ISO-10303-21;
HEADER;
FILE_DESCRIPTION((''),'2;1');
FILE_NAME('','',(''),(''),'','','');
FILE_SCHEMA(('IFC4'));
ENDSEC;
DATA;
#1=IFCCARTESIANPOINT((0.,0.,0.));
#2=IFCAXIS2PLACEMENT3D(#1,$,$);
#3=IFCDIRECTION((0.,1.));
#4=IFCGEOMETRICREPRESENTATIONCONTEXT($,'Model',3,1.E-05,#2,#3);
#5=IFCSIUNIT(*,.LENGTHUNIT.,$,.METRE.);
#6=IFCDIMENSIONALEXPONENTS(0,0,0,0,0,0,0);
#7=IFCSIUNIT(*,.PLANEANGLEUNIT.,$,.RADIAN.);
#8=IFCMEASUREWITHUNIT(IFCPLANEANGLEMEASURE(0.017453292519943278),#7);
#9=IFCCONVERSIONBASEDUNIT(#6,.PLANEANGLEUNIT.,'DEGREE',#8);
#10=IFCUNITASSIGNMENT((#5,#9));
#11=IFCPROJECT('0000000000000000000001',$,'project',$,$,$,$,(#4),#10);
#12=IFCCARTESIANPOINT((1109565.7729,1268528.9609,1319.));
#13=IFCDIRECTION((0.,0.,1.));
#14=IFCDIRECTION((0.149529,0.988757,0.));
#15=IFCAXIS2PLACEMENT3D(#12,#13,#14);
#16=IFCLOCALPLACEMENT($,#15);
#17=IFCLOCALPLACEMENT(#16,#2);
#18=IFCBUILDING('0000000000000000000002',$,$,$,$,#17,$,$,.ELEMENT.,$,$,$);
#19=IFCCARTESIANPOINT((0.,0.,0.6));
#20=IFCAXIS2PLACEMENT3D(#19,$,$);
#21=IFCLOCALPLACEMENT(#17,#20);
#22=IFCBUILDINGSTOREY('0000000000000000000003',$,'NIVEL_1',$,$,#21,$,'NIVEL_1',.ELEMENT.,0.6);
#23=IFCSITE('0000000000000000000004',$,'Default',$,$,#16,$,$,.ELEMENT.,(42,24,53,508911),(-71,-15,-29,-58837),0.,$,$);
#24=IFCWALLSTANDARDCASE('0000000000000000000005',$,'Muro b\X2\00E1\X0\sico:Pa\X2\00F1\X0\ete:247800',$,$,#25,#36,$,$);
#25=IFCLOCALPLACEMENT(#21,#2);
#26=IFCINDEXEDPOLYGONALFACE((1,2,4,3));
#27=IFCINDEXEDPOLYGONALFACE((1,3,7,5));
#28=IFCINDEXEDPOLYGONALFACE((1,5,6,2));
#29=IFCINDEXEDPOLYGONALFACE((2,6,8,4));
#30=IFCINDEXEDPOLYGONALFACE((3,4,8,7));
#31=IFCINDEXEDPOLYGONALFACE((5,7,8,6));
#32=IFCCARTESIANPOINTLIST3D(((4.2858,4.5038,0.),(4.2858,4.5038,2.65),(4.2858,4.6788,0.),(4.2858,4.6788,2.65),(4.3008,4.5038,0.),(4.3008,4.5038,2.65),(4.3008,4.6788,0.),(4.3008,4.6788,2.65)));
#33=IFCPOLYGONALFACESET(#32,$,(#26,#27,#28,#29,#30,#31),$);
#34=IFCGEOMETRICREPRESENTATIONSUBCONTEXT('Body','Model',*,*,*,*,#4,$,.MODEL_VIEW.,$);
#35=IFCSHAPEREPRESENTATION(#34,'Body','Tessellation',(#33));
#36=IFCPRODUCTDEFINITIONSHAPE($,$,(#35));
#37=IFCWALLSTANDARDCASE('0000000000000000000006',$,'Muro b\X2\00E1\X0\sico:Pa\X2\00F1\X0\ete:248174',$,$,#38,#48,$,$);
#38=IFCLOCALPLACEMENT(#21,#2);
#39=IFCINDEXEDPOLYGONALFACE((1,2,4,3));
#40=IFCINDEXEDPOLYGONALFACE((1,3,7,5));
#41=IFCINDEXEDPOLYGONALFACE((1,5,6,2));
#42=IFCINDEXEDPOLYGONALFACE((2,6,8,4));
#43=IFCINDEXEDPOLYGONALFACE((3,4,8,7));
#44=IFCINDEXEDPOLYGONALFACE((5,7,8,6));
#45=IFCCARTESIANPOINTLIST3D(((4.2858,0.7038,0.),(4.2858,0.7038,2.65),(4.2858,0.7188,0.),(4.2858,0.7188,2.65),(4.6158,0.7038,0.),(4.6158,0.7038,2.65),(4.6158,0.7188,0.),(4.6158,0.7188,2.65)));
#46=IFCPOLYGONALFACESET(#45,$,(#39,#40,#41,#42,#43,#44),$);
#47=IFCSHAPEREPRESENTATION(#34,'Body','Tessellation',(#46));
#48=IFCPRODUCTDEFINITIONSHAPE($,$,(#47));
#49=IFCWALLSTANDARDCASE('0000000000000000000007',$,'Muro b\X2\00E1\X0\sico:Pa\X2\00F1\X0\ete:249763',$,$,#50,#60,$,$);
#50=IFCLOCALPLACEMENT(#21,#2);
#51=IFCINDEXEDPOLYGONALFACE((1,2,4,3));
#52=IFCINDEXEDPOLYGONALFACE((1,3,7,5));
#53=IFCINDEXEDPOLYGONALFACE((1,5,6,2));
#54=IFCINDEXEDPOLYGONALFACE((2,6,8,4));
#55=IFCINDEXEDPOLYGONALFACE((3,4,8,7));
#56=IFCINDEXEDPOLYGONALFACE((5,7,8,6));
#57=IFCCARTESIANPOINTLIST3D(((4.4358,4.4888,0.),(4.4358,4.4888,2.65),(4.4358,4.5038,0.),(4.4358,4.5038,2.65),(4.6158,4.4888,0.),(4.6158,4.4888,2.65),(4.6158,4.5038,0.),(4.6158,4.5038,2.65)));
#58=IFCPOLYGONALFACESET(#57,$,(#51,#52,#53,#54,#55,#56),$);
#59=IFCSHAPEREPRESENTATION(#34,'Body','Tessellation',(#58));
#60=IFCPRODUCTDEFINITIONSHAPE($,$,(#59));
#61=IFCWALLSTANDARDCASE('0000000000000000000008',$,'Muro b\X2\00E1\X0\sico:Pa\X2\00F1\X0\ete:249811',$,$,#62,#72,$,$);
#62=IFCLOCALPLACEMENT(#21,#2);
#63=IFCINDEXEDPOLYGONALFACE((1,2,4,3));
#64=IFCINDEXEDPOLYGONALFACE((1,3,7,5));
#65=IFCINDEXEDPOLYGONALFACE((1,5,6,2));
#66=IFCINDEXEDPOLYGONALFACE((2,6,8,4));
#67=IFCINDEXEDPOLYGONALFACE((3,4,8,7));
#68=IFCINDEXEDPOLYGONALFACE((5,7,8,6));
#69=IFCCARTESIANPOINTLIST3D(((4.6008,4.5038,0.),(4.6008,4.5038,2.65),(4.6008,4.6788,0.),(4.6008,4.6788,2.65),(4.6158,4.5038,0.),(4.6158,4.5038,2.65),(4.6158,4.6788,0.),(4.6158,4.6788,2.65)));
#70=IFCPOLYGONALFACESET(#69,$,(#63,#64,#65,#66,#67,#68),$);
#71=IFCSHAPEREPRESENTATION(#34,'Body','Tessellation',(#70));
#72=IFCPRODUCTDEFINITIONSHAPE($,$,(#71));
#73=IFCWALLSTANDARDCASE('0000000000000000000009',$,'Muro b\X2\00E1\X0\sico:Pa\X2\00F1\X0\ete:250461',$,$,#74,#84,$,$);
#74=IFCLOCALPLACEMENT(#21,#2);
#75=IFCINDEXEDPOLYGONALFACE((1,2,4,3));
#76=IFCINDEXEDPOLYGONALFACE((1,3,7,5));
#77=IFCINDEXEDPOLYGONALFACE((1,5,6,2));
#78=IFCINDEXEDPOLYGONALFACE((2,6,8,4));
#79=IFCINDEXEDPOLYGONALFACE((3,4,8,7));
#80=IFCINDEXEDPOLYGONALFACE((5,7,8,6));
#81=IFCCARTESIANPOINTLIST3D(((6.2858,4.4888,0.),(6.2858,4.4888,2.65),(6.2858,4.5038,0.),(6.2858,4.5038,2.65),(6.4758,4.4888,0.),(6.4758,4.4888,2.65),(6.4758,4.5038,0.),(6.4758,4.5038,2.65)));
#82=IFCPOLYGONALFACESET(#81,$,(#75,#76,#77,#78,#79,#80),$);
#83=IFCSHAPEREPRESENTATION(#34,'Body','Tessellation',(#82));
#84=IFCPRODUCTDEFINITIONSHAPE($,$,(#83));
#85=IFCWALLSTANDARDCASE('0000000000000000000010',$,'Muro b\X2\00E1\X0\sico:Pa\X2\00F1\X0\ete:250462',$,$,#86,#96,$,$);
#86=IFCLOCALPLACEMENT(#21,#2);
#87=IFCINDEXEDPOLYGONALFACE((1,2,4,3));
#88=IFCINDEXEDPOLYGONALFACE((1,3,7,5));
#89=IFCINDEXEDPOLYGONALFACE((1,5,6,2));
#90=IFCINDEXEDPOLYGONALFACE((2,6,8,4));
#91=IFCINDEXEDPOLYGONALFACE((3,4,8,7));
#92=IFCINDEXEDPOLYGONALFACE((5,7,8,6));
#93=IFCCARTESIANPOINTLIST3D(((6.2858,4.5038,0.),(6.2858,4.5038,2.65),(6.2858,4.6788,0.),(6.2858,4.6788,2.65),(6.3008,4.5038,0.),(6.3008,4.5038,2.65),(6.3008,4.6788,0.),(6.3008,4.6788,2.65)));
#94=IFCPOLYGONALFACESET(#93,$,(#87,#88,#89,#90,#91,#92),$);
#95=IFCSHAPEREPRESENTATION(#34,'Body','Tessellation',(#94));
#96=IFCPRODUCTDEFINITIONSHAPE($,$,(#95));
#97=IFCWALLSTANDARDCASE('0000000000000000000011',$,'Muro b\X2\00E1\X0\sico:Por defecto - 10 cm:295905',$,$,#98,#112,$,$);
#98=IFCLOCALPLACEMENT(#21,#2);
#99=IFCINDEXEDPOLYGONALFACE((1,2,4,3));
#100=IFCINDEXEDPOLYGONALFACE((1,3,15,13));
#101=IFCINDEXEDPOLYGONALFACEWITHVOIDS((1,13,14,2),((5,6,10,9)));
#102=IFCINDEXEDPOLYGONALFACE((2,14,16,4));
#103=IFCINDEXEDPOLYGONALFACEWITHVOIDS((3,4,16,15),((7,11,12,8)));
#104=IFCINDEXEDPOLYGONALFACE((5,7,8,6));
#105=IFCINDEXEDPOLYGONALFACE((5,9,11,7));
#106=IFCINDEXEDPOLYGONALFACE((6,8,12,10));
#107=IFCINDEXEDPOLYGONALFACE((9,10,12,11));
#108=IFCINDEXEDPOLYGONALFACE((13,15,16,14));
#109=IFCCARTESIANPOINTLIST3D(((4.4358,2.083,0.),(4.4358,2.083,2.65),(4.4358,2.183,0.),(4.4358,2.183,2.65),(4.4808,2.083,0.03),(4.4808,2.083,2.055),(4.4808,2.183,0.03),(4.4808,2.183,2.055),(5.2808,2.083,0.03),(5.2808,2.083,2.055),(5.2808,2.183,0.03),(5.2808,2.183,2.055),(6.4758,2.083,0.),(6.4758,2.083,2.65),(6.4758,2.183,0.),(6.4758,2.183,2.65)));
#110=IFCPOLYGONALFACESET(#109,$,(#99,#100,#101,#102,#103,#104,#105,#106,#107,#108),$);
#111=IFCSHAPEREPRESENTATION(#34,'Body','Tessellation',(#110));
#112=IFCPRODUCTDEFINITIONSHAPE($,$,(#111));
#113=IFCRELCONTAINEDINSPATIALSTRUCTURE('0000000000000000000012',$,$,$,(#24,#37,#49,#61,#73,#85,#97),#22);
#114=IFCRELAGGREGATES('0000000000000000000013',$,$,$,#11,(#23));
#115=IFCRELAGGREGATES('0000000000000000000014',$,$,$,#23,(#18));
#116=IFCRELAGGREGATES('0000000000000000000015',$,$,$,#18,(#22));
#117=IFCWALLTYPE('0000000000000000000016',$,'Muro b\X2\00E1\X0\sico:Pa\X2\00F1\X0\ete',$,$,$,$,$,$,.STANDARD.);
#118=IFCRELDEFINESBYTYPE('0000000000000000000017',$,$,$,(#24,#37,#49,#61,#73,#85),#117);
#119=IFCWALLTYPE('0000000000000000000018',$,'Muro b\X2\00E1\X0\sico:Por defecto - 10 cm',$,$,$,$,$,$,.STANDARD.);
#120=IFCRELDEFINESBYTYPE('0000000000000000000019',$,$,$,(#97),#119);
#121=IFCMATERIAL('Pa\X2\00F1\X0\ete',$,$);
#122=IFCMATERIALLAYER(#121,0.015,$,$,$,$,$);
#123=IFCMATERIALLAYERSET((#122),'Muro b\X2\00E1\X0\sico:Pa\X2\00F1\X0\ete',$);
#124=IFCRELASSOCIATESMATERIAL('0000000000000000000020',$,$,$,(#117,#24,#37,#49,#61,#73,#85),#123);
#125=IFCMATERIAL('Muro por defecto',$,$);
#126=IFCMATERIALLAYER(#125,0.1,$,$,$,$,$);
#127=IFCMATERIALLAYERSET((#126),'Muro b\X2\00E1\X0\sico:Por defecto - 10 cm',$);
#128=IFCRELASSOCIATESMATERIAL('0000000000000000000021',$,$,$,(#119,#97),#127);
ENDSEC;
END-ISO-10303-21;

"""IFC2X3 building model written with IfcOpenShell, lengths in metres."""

from ifc_helpers import new_model, entity, si_unit, converted_unit, direction, frame, frame_2d, origin, place, context, subcontext, project, spatial, rectangle, extrude, material, layer, layer_set, layer_usage, type_object, element, save


model = new_model("IFC2X3")

# Units and contexts
model_context = context("Model", 3, precision=1e-05, world=origin(), true_north=direction((0.0, 1.0)))
body_context = subcontext(model_context, "Body", "Model", "MODEL_VIEW")
ifc_project = project(units=[si_unit("LENGTHUNIT", "METRE"), converted_unit("PLANEANGLEUNIT", "DEGREE", entity("IfcPlaneAngleMeasure", 0.017453292519943278), si_unit("PLANEANGLEUNIT", "RADIAN"), dimensions=[0, 0, 0, 0, 0, 0, 0])], contexts=[model_context])

# Site, building, storey
site_placement = place(None, frame((1109565.7729, 1268528.9609, 1319.0), z_axis=(0.0, 0.0, 1.0), x_axis=(0.149529, 0.988757, 0.0)))
site = spatial("IfcSite", under=ifc_project, at=site_placement, Name="Default", CompositionType="ELEMENT", RefLatitude=(42, 24, 53, 508911), RefLongitude=(-71, -15, -29, -58837), RefElevation=0.0)
building_placement = place(site_placement, origin())
building = spatial("IfcBuilding", under=site, at=building_placement, CompositionType="ELEMENT")
storey_placement = place(building_placement, frame((0.0, 0.0, 0.6)))
storey = spatial("IfcBuildingStorey", under=building, at=storey_placement, Name="NIVEL_1", LongName="NIVEL_1", CompositionType="ELEMENT", Elevation=0.6)

# Shared definitions
ifc_material_1 = material(Name="Pañete")

# Walls
ifc_layer_1 = layer(ifc_material_1, 0.015)
ifc_layer_set_1 = layer_set([ifc_layer_1], Name="Muro básico:Pañete")
ifc_layer_usage_1 = layer_usage(ifc_layer_set_1, "AXIS2", "NEGATIVE", 0.0075)
wall_type_1 = type_object("IfcWallType", Name="Muro básico:Pañete", PredefinedType="STANDARD", material=ifc_layer_set_1)
wall_1_placement = place(storey_placement, frame((4.2933, 4.5038, 0.0), z_axis=(0.0, 0.0, 1.0), x_axis=(0.0, 1.0, 0.0)))
element("IfcWallStandardCase", 1, at=wall_1_placement, inside=storey, type_object=wall_type_1, material=ifc_layer_usage_1, Name="Muro básico:Pañete:247800", context=body_context, shape_type="SweptSolid", body=[
    extrude(rectangle(XDim=0.175, YDim=0.015, at=frame_2d((0.0875, 0.0), x_axis=(-1.0, 0.0))), origin(), (0.0, 0.0, 1.0), 2.65),
])
ifc_layer_usage_2 = layer_usage(ifc_layer_set_1, "AXIS2", "NEGATIVE", 0.0075)
wall_2_placement = place(storey_placement, frame((4.2858, 0.7113, 0.0)))
element("IfcWallStandardCase", 2, at=wall_2_placement, inside=storey, type_object=wall_type_1, material=ifc_layer_usage_2, Name="Muro básico:Pañete:248174", context=body_context, shape_type="SweptSolid", body=[
    extrude(rectangle(XDim=0.33, YDim=0.015, at=frame_2d((0.165, 0.0), x_axis=(-1.0, 0.0))), origin(), (0.0, 0.0, 1.0), 2.65),
])
ifc_layer_usage_3 = layer_usage(ifc_layer_set_1, "AXIS2", "POSITIVE", -0.0075)
wall_3_placement = place(storey_placement, frame((4.4358, 4.4963, 0.0)))
element("IfcWallStandardCase", 3, at=wall_3_placement, inside=storey, type_object=wall_type_1, material=ifc_layer_usage_3, Name="Muro básico:Pañete:249763", context=body_context, shape_type="SweptSolid", body=[
    extrude(rectangle(XDim=0.18, YDim=0.015, at=frame_2d((0.09, 0.0), x_axis=(-1.0, 0.0))), origin(), (0.0, 0.0, 1.0), 2.65),
])
ifc_layer_usage_4 = layer_usage(ifc_layer_set_1, "AXIS2", "POSITIVE", -0.0075)
wall_4_placement = place(storey_placement, frame((4.6083, 4.5038, 0.0), z_axis=(0.0, 0.0, 1.0), x_axis=(0.0, 1.0, 0.0)))
element("IfcWallStandardCase", 4, at=wall_4_placement, inside=storey, type_object=wall_type_1, material=ifc_layer_usage_4, Name="Muro básico:Pañete:249811", context=body_context, shape_type="SweptSolid", body=[
    extrude(rectangle(XDim=0.175, YDim=0.015, at=frame_2d((0.0875, 0.0), x_axis=(-1.0, 0.0))), origin(), (0.0, 0.0, 1.0), 2.65),
])
ifc_layer_usage_5 = layer_usage(ifc_layer_set_1, "AXIS2", "NEGATIVE", 0.0075)
wall_5_placement = place(storey_placement, frame((6.4758, 4.4963, 0.0), z_axis=(0.0, 0.0, 1.0), x_axis=(-1.0, 0.0, 0.0)))
element("IfcWallStandardCase", 5, at=wall_5_placement, inside=storey, type_object=wall_type_1, material=ifc_layer_usage_5, Name="Muro básico:Pañete:250461", context=body_context, shape_type="SweptSolid", body=[
    extrude(rectangle(XDim=0.19, YDim=0.015, at=frame_2d((0.095, 0.0), x_axis=(-1.0, 0.0))), origin(), (0.0, 0.0, 1.0), 2.65),
])
ifc_layer_usage_6 = layer_usage(ifc_layer_set_1, "AXIS2", "NEGATIVE", 0.0075)
wall_6_placement = place(storey_placement, frame((6.2933, 4.5038, 0.0), z_axis=(0.0, 0.0, 1.0), x_axis=(0.0, 1.0, 0.0)))
element("IfcWallStandardCase", 6, at=wall_6_placement, inside=storey, type_object=wall_type_1, material=ifc_layer_usage_6, Name="Muro básico:Pañete:250462", context=body_context, shape_type="SweptSolid", body=[
    extrude(rectangle(XDim=0.175, YDim=0.015, at=frame_2d((0.0875, 0.0), x_axis=(-1.0, 0.0))), origin(), (0.0, 0.0, 1.0), 2.65),
])

# Wall, opening
ifc_material_2 = material(Name="Muro por defecto")
ifc_layer_2 = layer(ifc_material_2, 0.1)
ifc_layer_set_2 = layer_set([ifc_layer_2], Name="Muro básico:Por defecto - 10 cm")
ifc_layer_usage_7 = layer_usage(ifc_layer_set_2, "AXIS2", "NEGATIVE", 0.05)
wall_type_2 = type_object("IfcWallType", Name="Muro básico:Por defecto - 10 cm", PredefinedType="STANDARD", material=ifc_layer_set_2)
wall_7_placement = place(storey_placement, frame((6.4758, 2.133, 0.0), z_axis=(0.0, 0.0, 1.0), x_axis=(-1.0, 0.0, 0.0)))
wall_7 = element("IfcWallStandardCase", 7, at=wall_7_placement, inside=storey, type_object=wall_type_2, material=ifc_layer_usage_7, Name="Muro básico:Por defecto - 10 cm:295905", context=body_context, shape_type="SweptSolid", body=[
    extrude(rectangle(XDim=2.04, YDim=0.1, at=frame_2d((1.02, 0.0), x_axis=(-1.0, 0.0))), origin(), (0.0, 0.0, 1.0), 2.65),
])
opening_1_placement = place(wall_7_placement, frame((1.995, 0.05, 0.03)))
element("IfcOpeningElement", 8, at=opening_1_placement, cuts=wall_7, ObjectType="Opening", context=body_context, shape_type="SweptSolid", body=[
    extrude(rectangle(XDim=2.025, YDim=0.8, at=frame_2d((1.0125, 0.4), x_axis=(1.0, 0.0))), frame((0.0, 0.0, 0.0), z_axis=(0.0, -1.0, 0.0), x_axis=(0.0, 0.0, 1.0)), (0.0, 0.0, 1.0), 0.1),
])

save(model, "model.ifc")
